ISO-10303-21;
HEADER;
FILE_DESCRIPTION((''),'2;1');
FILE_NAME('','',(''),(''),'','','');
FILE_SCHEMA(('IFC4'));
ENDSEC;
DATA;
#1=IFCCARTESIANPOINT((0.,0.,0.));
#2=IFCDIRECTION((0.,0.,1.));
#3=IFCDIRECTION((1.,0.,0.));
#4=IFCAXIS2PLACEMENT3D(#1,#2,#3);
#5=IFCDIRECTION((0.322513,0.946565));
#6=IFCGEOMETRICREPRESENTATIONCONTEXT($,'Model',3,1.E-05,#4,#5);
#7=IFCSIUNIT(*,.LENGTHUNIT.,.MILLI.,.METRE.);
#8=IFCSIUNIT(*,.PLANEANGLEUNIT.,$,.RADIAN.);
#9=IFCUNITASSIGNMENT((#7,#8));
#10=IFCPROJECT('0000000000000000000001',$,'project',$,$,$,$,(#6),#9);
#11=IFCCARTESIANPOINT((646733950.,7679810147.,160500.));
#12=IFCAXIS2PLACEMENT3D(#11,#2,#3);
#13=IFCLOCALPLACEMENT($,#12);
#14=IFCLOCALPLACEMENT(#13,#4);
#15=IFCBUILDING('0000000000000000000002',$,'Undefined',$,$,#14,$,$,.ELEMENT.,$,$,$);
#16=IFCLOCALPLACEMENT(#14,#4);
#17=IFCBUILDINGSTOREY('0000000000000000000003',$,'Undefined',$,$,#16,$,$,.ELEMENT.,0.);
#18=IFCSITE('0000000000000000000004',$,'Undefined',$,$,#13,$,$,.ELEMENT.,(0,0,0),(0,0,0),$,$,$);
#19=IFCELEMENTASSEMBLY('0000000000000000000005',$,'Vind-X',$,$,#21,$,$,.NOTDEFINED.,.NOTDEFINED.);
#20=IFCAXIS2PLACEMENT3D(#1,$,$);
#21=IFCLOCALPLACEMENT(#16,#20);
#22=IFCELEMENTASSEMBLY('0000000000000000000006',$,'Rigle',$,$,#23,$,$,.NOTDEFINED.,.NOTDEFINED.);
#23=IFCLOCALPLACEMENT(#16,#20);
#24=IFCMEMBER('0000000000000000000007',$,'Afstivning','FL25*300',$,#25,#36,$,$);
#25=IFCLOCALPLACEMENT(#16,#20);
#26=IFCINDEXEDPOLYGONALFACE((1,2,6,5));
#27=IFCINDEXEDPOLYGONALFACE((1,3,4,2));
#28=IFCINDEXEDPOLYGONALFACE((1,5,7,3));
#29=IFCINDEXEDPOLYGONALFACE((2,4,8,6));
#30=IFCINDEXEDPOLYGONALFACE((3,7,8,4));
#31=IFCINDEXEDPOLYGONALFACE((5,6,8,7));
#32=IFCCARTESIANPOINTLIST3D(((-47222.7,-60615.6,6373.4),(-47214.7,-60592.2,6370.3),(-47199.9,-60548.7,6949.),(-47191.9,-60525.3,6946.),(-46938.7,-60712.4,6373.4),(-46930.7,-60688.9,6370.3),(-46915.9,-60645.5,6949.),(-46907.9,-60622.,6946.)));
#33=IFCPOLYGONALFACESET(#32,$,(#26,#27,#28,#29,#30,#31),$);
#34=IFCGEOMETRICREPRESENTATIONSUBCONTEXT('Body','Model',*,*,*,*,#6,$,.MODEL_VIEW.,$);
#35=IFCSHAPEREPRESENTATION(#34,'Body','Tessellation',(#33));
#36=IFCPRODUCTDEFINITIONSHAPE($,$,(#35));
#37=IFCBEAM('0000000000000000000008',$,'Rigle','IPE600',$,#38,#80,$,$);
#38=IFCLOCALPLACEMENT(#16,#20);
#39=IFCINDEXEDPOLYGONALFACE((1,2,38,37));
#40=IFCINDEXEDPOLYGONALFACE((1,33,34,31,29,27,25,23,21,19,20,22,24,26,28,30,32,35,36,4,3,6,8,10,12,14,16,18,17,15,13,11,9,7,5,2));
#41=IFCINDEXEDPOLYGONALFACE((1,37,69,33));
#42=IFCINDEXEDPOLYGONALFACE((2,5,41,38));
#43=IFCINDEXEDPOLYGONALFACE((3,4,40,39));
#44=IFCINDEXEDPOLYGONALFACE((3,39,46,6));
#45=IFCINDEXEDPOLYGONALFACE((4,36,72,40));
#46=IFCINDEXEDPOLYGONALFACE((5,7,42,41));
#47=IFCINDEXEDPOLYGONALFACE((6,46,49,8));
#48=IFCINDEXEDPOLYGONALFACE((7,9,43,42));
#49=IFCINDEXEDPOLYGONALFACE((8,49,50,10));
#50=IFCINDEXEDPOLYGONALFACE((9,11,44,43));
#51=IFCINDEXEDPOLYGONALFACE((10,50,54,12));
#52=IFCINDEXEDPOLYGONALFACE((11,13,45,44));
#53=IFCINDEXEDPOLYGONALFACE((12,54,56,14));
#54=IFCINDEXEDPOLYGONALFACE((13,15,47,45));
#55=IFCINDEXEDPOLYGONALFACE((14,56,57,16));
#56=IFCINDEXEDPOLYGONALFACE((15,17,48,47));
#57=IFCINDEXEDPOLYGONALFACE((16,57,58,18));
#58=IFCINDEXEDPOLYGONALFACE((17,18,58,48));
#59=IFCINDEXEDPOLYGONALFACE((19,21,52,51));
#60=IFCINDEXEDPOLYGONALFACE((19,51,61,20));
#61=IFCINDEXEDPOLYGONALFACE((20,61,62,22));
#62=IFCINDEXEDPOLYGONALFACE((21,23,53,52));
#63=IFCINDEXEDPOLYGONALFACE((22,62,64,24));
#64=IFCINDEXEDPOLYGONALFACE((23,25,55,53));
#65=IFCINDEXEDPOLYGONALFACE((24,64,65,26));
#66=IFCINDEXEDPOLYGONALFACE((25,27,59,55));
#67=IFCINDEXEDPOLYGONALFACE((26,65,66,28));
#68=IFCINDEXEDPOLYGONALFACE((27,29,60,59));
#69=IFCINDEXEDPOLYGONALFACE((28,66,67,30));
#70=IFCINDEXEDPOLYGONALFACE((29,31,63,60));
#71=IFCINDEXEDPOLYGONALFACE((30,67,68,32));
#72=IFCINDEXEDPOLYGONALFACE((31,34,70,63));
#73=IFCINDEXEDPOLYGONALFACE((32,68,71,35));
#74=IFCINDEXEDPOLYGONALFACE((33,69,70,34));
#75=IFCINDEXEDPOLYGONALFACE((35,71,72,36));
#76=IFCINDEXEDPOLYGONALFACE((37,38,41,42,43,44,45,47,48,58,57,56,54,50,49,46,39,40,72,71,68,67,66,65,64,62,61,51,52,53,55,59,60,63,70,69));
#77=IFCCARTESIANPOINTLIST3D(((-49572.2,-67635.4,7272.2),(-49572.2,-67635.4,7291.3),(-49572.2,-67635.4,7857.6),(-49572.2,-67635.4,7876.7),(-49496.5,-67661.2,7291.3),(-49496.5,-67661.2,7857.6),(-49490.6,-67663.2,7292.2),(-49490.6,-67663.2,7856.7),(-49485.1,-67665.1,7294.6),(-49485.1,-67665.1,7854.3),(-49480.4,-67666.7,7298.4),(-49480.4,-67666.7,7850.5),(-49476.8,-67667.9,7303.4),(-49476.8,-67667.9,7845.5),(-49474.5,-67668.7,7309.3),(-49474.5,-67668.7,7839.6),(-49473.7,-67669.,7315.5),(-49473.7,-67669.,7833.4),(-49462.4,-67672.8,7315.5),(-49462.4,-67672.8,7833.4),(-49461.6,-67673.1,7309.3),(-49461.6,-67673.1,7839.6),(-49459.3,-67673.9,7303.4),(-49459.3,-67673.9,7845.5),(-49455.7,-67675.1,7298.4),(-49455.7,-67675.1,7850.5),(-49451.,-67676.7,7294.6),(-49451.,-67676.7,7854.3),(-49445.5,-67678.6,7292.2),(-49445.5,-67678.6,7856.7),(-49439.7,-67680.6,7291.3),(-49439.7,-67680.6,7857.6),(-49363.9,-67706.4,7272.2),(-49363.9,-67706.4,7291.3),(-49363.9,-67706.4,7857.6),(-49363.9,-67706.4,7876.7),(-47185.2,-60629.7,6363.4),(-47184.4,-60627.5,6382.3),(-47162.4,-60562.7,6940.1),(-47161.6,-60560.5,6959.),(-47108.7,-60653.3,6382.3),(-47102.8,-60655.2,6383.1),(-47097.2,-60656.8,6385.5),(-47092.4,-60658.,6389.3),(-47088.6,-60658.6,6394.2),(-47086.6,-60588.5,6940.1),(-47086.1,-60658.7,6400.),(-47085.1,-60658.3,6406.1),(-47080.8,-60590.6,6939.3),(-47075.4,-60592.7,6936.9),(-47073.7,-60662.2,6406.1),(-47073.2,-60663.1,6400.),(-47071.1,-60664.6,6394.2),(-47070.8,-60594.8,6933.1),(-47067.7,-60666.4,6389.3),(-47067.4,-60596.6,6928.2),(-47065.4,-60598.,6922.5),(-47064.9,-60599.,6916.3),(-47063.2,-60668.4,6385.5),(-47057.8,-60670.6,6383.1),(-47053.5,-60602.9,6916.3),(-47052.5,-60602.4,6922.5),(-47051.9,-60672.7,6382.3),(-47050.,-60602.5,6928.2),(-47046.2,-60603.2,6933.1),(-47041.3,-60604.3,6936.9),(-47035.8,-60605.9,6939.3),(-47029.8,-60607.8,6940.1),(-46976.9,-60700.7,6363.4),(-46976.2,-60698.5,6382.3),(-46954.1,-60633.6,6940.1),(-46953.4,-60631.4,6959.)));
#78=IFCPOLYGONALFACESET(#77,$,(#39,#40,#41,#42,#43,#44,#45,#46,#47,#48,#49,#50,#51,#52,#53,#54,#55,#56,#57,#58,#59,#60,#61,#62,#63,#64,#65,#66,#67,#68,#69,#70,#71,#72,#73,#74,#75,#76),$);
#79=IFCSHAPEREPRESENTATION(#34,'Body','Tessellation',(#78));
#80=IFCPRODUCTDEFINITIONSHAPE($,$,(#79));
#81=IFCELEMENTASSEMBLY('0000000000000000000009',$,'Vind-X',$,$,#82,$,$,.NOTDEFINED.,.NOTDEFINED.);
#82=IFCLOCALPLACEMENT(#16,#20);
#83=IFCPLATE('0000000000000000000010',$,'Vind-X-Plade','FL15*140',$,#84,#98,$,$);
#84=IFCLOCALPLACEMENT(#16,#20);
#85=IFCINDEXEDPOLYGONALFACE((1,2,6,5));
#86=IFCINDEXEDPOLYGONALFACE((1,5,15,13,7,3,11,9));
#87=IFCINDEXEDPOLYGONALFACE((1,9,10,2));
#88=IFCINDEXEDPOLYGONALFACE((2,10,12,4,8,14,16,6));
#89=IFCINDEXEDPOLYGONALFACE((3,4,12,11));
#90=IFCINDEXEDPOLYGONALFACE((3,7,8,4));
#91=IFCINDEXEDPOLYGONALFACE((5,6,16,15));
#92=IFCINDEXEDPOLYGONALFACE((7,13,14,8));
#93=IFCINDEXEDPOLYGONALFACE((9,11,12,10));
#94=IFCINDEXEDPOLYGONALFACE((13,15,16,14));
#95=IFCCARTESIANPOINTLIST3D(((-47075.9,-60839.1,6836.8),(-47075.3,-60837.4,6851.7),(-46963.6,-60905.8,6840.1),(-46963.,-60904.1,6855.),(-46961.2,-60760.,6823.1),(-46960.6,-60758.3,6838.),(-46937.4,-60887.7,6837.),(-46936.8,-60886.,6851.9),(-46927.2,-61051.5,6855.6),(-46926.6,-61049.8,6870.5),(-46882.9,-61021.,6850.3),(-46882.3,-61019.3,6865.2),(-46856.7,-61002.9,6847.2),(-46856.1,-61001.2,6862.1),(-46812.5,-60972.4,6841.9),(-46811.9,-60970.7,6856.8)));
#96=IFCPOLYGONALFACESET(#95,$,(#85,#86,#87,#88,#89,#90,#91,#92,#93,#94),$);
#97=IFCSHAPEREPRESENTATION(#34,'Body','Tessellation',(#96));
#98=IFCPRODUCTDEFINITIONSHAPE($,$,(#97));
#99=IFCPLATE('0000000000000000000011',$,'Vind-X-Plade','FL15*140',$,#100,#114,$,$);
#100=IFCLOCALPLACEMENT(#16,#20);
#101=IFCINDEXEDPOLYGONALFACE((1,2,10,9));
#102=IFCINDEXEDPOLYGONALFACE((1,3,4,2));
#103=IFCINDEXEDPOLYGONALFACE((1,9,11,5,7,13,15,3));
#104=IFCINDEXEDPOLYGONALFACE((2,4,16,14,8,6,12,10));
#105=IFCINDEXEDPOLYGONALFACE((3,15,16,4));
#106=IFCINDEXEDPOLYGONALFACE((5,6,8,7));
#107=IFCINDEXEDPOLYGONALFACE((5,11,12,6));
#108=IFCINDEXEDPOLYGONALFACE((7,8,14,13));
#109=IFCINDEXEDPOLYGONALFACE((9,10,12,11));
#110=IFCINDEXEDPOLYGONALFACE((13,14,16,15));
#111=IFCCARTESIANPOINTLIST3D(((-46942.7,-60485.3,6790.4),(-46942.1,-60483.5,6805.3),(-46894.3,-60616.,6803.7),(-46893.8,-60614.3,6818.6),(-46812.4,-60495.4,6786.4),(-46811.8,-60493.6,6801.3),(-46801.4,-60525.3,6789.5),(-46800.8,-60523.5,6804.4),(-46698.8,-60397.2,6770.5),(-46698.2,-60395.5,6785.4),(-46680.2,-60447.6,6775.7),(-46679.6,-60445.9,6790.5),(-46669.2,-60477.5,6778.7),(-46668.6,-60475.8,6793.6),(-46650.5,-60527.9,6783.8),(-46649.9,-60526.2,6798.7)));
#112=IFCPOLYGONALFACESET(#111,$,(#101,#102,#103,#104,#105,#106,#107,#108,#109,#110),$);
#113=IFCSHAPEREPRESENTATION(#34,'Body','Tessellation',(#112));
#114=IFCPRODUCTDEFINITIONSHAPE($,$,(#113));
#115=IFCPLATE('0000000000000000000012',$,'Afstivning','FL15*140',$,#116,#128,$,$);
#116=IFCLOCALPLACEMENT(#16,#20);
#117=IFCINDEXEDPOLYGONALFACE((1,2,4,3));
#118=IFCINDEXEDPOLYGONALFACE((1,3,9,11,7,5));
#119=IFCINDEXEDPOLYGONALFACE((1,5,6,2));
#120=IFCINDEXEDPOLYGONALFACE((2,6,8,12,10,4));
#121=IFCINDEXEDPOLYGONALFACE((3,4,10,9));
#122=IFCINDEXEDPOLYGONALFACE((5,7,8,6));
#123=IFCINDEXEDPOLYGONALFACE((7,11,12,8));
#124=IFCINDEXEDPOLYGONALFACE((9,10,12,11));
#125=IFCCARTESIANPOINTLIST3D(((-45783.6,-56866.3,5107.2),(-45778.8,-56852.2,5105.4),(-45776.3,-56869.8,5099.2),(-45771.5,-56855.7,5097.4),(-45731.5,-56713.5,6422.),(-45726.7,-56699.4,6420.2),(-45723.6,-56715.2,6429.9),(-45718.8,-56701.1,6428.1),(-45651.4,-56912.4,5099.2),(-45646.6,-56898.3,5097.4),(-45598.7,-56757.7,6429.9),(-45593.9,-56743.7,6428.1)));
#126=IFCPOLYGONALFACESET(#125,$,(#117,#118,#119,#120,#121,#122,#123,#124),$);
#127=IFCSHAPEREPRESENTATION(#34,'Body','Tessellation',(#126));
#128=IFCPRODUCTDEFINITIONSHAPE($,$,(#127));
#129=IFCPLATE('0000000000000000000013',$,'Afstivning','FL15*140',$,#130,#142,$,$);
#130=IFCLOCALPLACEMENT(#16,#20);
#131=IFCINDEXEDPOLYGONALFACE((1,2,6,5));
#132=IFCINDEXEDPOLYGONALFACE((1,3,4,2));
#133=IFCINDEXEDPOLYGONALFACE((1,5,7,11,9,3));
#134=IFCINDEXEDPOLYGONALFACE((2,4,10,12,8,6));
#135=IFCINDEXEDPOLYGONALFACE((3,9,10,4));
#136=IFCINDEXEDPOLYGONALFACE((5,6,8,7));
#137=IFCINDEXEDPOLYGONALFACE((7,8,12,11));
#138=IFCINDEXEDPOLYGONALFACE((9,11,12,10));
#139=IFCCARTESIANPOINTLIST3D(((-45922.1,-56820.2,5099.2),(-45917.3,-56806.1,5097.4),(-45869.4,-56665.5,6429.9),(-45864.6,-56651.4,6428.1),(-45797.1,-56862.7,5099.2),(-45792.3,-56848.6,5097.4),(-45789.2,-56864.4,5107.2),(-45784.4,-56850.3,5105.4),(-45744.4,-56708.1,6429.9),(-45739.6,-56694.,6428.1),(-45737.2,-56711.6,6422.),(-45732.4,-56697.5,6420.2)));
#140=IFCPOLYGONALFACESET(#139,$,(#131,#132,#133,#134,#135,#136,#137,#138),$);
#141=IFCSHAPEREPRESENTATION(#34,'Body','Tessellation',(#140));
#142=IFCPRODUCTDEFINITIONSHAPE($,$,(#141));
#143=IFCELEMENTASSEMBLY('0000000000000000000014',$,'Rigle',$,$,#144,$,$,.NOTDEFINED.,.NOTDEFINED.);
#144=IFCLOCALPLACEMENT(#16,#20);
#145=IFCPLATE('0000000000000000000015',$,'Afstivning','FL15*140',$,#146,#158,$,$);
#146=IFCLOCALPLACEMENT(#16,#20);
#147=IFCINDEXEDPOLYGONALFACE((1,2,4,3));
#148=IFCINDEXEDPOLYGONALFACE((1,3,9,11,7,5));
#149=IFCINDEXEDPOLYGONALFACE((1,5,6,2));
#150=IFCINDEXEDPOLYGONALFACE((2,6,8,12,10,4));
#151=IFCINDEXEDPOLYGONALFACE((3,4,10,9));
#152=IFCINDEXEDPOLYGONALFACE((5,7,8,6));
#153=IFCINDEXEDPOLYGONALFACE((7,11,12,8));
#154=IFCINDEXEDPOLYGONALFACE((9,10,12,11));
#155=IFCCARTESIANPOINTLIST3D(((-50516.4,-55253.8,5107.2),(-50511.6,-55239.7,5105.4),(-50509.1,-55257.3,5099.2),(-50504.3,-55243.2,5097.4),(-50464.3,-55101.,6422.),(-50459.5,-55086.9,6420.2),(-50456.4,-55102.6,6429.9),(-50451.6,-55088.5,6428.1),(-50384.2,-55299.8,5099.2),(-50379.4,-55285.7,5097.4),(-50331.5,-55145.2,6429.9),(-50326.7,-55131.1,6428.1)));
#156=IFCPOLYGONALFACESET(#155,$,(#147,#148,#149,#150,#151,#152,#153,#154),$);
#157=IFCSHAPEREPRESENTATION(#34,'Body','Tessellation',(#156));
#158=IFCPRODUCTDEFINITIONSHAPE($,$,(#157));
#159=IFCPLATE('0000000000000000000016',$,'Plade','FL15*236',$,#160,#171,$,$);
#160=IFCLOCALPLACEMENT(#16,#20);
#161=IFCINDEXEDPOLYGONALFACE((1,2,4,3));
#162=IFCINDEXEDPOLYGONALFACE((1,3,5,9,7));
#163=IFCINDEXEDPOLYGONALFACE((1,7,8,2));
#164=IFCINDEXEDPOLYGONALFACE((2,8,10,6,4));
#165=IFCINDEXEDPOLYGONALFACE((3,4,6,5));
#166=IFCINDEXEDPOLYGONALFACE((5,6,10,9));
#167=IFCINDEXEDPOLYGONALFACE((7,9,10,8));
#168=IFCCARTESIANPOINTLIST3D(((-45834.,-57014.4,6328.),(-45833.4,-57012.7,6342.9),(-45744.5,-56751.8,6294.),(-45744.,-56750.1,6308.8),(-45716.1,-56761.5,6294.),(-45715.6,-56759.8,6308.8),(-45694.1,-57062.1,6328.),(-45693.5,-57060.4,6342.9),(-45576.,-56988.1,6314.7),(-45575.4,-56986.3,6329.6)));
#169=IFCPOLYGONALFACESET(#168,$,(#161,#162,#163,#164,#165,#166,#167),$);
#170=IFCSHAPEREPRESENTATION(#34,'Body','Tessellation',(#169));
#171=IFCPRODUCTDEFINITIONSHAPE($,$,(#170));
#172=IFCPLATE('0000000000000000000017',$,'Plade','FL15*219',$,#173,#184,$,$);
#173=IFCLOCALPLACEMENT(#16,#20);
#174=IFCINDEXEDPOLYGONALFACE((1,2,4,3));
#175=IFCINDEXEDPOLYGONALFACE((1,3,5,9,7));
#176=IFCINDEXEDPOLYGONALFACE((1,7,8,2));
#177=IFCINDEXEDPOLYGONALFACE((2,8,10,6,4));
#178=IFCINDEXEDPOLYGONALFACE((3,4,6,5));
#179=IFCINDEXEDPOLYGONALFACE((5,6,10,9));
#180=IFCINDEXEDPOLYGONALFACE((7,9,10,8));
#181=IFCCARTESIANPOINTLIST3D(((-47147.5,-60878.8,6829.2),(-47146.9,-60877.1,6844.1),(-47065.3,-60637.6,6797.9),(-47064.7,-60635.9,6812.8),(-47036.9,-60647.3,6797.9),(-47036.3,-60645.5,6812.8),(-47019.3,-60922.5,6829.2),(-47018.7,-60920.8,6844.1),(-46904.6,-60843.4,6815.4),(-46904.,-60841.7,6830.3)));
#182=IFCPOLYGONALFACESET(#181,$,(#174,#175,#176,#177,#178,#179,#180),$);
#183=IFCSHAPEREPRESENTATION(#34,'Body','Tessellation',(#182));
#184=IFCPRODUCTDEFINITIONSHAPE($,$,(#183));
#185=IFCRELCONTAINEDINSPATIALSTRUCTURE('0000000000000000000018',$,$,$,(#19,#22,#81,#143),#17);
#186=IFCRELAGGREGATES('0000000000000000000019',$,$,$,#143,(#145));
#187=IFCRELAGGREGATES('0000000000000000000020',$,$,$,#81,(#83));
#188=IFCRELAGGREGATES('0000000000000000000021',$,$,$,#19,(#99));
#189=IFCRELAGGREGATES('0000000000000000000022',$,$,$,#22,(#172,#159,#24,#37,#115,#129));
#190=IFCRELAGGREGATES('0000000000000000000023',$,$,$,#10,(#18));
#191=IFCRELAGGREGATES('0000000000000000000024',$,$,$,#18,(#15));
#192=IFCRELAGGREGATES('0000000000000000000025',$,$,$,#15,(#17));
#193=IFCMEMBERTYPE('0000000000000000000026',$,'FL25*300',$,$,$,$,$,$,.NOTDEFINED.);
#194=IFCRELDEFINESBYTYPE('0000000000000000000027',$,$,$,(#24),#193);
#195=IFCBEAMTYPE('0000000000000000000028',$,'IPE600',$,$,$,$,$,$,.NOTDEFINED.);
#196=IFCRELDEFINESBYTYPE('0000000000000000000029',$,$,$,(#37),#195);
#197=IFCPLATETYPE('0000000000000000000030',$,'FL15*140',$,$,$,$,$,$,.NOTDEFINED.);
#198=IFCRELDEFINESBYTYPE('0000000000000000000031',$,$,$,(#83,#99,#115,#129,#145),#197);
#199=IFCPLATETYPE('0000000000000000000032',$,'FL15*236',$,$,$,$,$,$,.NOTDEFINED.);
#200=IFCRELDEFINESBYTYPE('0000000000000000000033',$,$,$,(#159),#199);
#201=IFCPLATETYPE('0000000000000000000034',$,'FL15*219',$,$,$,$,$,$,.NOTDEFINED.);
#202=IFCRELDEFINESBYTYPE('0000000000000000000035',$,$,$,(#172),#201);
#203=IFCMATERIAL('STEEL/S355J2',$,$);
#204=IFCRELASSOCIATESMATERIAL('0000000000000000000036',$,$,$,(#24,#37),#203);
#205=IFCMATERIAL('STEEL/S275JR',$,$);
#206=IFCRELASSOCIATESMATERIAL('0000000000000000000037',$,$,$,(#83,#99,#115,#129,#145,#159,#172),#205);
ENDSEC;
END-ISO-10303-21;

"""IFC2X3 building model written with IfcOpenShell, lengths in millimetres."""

from ifc_helpers import new_model, si_unit, direction, frame, origin_with_axes, origin_2d_with_axis, place, context, subcontext, project, spatial, polyline, rectangle, i_section, outline, extrude, clip, halfspace, material, type_object, element, aggregate, save


model = new_model("IFC2X3")

# Units and contexts
model_context = context("Model", 3, precision=1e-05, world=origin_with_axes(), true_north=direction((0.322513, 0.946565)))
body_context = subcontext(model_context, "Body", "Model", "MODEL_VIEW")
ifc_project = project(units=[si_unit("LENGTHUNIT", "METRE", prefix="MILLI"), si_unit("PLANEANGLEUNIT", "RADIAN")], contexts=[model_context])

# Site, building, storey
site_placement = place(None, frame((646733950.0, 7679810147.0, 160500.0), z_axis=(0.0, 0.0, 1.0), x_axis=(1.0, 0.0, 0.0)))
site = spatial("IfcSite", under=ifc_project, at=site_placement, Name="Undefined", CompositionType="ELEMENT", RefLatitude=(0, 0, 0), RefLongitude=(0, 0, 0))
building_placement = place(site_placement, origin_with_axes())
building = spatial("IfcBuilding", under=site, at=building_placement, Name="Undefined", CompositionType="ELEMENT")
storey_placement = place(building_placement, origin_with_axes())
storey = spatial("IfcBuildingStorey", under=building, at=storey_placement, Name="Undefined", CompositionType="ELEMENT", Elevation=0.0)

# Element assembly
assembly_1_placement = place(storey_placement, origin_with_axes())
assembly_1 = element("IfcElementAssembly", 1, at=assembly_1_placement, inside=storey, Name="Vind-X", AssemblyPlace="NOTDEFINED", PredefinedType="NOTDEFINED")
ifc_material_1 = material(Name="STEEL/S355J2")

# Element assembly, member, beam
assembly_2_placement = place(storey_placement, origin_with_axes())
assembly_2 = element("IfcElementAssembly", 2, at=assembly_2_placement, inside=storey, Name="Rigle", AssemblyPlace="NOTDEFINED", PredefinedType="NOTDEFINED")
member_type_1 = type_object("IfcMemberType", Name="FL25*300", PredefinedType="NOTDEFINED")
member_1_placement = place(assembly_2_placement, frame((-47053.9, -60585.4, 6947.5), z_axis=(-0.946565, 0.322513, 0.0), x_axis=(-0.039304, -0.115357, -0.992546)))
member_1 = element("IfcMember", 3, at=member_1_placement, type_object=member_type_1, material=ifc_material_1, Name="Afstivning", Description="FL25*300", context=body_context, shape_type="SweptSolid", body=[
    extrude(rectangle(XDim=25.0, YDim=300.0, at=origin_2d_with_axis()), frame((580.0, 0.0, 0.0), z_axis=(-1.0, 0.0, 0.0), x_axis=(0.0, -1.0, 0.0)), (0.0, 0.0, 1.0), 580.0),
])
beam_type_1 = type_object("IfcBeamType", Name="IPE600", PredefinedType="NOTDEFINED")
beam_1_placement = place(assembly_2_placement, frame((-47065.3, -60618.8, 6659.7), z_axis=(0.039304, 0.115357, 0.992546), x_axis=(-0.320109, -0.93951, 0.121869)))
beam_1 = element("IfcBeam", 4, at=beam_1_placement, type_object=beam_type_1, material=ifc_material_1, Name="Rigle", Description="IPE600", context=body_context, shape_type="Clipping", body=[
    clip(clip(extrude(i_section(OverallWidth=220.0, OverallDepth=600.0, WebThickness=12.0, FlangeThickness=19.0, FilletRadius=24.0, at=origin_2d_with_axis()), frame((7751.3, 0.0, 0.0), z_axis=(-1.0, 0.0, 0.0), x_axis=(0.0, -1.0, 0.0)), (0.0, 0.0, 1.0), 7983.9), halfspace(frame((7543.3, 0.0, 303.0), z_axis=(0.992546, 0.0, -0.121869), x_axis=(0.0, 1.0, 0.0)), False)), halfspace(frame((12.5, 0.0, 0.0), z_axis=(-1.0, 0.0, 0.0), x_axis=(0.0, 1.0, 0.0)), False)),
])

# Element assembly, plate
assembly_3_placement = place(storey_placement, origin_with_axes())
assembly_3 = element("IfcElementAssembly", 5, at=assembly_3_placement, inside=storey, Name="Vind-X", AssemblyPlace="NOTDEFINED", PredefinedType="NOTDEFINED")
ifc_material_2 = material(Name="STEEL/S275JR")
plate_type_1 = type_object("IfcPlateType", Name="FL15*140", PredefinedType="NOTDEFINED")
plate_1_placement = place(assembly_3_placement, frame((-46812.2, -60971.6, 6849.3), z_axis=(0.039304, 0.115357, 0.992546), x_axis=(-0.572042, 0.817031, -0.072306)))
plate_1 = element("IfcPlate", 6, at=plate_1_placement, type_object=plate_type_1, material=ifc_material_2, Name="Vind-X-Plade", Description="FL15*140", context=body_context, shape_type="SweptSolid", body=[
    extrude(outline(polyline([(0.0, 0.0), (260.0, 0.0), (260.0, 140.0), (0.0, 140.0), (0.0, 86.0), (141.0, 86.0), (141.0, 54.0), (0.0, 54.0), (0.0, 0.0)])), frame((0.0, 0.0, -7.5), z_axis=(0.0, 0.0, 1.0), x_axis=(1.0, 0.0, 0.0)), (0.0, 0.0, 1.0), 15.0),
])

# Plates
plate_2_placement = place(assembly_1_placement, frame((-46698.5, -60396.3, 6778.0), z_axis=(0.039304, 0.115357, 0.992546), x_axis=(-0.937758, -0.338759, 0.076507)))
plate_2 = element("IfcPlate", 7, at=plate_2_placement, type_object=plate_type_1, material=ifc_material_2, Name="Vind-X-Plade", Description="FL15*140", context=body_context, shape_type="SweptSolid", body=[
    extrude(outline(polyline([(0.0, 0.0), (260.0, 0.0), (260.0, 140.0), (0.0, 140.0), (0.0, 86.0), (141.0, 86.0), (141.0, 54.0), (0.0, 54.0), (0.0, 0.0)])), frame((0.0, 0.0, -7.5), z_axis=(0.0, 0.0, 1.0), x_axis=(1.0, 0.0, 0.0)), (0.0, 0.0, 1.0), 15.0),
])
plate_3_placement = place(assembly_2_placement, frame((-45649.0, -56905.4, 5098.3), z_axis=(0.320109, 0.93951, -0.121869), x_axis=(-0.946565, 0.322513, 0.0)))
plate_3 = element("IfcPlate", 8, at=plate_3_placement, type_object=plate_type_1, material=ifc_material_2, Name="Afstivning", Description="FL15*140", context=body_context, shape_type="SweptSolid", body=[
    extrude(outline(polyline([(0.0, 0.0), (132.0, 0.0), (140.0, 8.0), (140.0, 1332.7), (132.0, 1340.7), (0.0, 1340.7), (0.0, 0.0)])), frame((0.0, 0.0, -7.5), z_axis=(0.0, 0.0, 1.0), x_axis=(1.0, 0.0, 0.0)), (0.0, 0.0, 1.0), 15.0),
])
plate_4_placement = place(assembly_2_placement, frame((-45787.2, -56858.3, 5098.3), z_axis=(0.320109, 0.93951, -0.121869), x_axis=(-0.946565, 0.322513, 0.0)))
plate_4 = element("IfcPlate", 9, at=plate_4_placement, type_object=plate_type_1, material=ifc_material_2, Name="Afstivning", Description="FL15*140", context=body_context, shape_type="SweptSolid", body=[
    extrude(outline(polyline([(0.0, 8.0), (8.0, 0.0), (140.0, 0.0), (140.0, 1340.7), (8.0, 1340.7), (0.0, 1332.7), (0.0, 8.0)])), frame((0.0, 0.0, -7.5), z_axis=(0.0, 0.0, 1.0), x_axis=(1.0, 0.0, 0.0)), (0.0, 0.0, 1.0), 15.0),
])

# Element assembly, plate
assembly_4_placement = place(storey_placement, origin_with_axes())
assembly_4 = element("IfcElementAssembly", 10, at=assembly_4_placement, inside=storey, Name="Rigle", AssemblyPlace="NOTDEFINED", PredefinedType="NOTDEFINED")
plate_5_placement = place(assembly_4_placement, frame((-50381.8, -55292.8, 5098.3), z_axis=(0.320109, 0.93951, -0.121869), x_axis=(-0.946565, 0.322513, 0.0)))
plate_5 = element("IfcPlate", 11, at=plate_5_placement, type_object=plate_type_1, material=ifc_material_2, Name="Afstivning", Description="FL15*140", context=body_context, shape_type="SweptSolid", body=[
    extrude(outline(polyline([(0.0, 0.0), (132.0, 0.0), (140.0, 8.0), (140.0, 1332.7), (132.0, 1340.7), (0.0, 1340.7), (0.0, 0.0)])), frame((0.0, 0.0, -7.5), z_axis=(0.0, 0.0, 1.0), x_axis=(1.0, 0.0, 0.0)), (0.0, 0.0, 1.0), 15.0),
])
aggregate(assembly_4, [plate_5])

# Plates
plate_type_2 = type_object("IfcPlateType", Name="FL15*236", PredefinedType="NOTDEFINED")
plate_6_placement = place(assembly_2_placement, frame((-45744.3, -56751.0, 6301.4), z_axis=(0.039304, 0.115357, 0.992546), x_axis=(-0.320109, -0.93951, 0.121869)))
plate_6 = element("IfcPlate", 12, at=plate_6_placement, type_object=plate_type_2, material=ifc_material_2, Name="Plade", Description="FL15*236", context=body_context, shape_type="SweptSolid", body=[
    extrude(outline(polyline([(0.0, 0.0), (279.5, 0.0), (279.5, 147.8), (170.6, 235.7), (0.0, 30.0), (0.0, 0.0)])), frame((0.0, 0.0, -7.5), z_axis=(0.0, 0.0, 1.0), x_axis=(1.0, 0.0, 0.0)), (0.0, 0.0, 1.0), 15.0),
])
plate_type_3 = type_object("IfcPlateType", Name="FL15*219", PredefinedType="NOTDEFINED")
plate_7_placement = place(assembly_2_placement, frame((-47065.0, -60636.7, 6805.3), z_axis=(0.039304, 0.115357, 0.992546), x_axis=(-0.320109, -0.93951, 0.121869)))
plate_7 = element("IfcPlate", 13, at=plate_7_placement, type_object=plate_type_3, material=ifc_material_2, Name="Plade", Description="FL15*219", context=body_context, shape_type="SweptSolid", body=[
    extrude(outline(polyline([(0.0, 0.0), (256.8, 0.0), (256.8, 135.5), (144.1, 218.6), (0.0, 30.0), (0.0, 0.0)])), frame((0.0, 0.0, -7.5), z_axis=(0.0, 0.0, 1.0), x_axis=(1.0, 0.0, 0.0)), (0.0, 0.0, 1.0), 15.0),
])

aggregate(assembly_3, [plate_1])

aggregate(assembly_1, [plate_2])
aggregate(assembly_2, [plate_7, plate_6, member_1, beam_1, plate_3, plate_4])

save(model, "model.ifc")
